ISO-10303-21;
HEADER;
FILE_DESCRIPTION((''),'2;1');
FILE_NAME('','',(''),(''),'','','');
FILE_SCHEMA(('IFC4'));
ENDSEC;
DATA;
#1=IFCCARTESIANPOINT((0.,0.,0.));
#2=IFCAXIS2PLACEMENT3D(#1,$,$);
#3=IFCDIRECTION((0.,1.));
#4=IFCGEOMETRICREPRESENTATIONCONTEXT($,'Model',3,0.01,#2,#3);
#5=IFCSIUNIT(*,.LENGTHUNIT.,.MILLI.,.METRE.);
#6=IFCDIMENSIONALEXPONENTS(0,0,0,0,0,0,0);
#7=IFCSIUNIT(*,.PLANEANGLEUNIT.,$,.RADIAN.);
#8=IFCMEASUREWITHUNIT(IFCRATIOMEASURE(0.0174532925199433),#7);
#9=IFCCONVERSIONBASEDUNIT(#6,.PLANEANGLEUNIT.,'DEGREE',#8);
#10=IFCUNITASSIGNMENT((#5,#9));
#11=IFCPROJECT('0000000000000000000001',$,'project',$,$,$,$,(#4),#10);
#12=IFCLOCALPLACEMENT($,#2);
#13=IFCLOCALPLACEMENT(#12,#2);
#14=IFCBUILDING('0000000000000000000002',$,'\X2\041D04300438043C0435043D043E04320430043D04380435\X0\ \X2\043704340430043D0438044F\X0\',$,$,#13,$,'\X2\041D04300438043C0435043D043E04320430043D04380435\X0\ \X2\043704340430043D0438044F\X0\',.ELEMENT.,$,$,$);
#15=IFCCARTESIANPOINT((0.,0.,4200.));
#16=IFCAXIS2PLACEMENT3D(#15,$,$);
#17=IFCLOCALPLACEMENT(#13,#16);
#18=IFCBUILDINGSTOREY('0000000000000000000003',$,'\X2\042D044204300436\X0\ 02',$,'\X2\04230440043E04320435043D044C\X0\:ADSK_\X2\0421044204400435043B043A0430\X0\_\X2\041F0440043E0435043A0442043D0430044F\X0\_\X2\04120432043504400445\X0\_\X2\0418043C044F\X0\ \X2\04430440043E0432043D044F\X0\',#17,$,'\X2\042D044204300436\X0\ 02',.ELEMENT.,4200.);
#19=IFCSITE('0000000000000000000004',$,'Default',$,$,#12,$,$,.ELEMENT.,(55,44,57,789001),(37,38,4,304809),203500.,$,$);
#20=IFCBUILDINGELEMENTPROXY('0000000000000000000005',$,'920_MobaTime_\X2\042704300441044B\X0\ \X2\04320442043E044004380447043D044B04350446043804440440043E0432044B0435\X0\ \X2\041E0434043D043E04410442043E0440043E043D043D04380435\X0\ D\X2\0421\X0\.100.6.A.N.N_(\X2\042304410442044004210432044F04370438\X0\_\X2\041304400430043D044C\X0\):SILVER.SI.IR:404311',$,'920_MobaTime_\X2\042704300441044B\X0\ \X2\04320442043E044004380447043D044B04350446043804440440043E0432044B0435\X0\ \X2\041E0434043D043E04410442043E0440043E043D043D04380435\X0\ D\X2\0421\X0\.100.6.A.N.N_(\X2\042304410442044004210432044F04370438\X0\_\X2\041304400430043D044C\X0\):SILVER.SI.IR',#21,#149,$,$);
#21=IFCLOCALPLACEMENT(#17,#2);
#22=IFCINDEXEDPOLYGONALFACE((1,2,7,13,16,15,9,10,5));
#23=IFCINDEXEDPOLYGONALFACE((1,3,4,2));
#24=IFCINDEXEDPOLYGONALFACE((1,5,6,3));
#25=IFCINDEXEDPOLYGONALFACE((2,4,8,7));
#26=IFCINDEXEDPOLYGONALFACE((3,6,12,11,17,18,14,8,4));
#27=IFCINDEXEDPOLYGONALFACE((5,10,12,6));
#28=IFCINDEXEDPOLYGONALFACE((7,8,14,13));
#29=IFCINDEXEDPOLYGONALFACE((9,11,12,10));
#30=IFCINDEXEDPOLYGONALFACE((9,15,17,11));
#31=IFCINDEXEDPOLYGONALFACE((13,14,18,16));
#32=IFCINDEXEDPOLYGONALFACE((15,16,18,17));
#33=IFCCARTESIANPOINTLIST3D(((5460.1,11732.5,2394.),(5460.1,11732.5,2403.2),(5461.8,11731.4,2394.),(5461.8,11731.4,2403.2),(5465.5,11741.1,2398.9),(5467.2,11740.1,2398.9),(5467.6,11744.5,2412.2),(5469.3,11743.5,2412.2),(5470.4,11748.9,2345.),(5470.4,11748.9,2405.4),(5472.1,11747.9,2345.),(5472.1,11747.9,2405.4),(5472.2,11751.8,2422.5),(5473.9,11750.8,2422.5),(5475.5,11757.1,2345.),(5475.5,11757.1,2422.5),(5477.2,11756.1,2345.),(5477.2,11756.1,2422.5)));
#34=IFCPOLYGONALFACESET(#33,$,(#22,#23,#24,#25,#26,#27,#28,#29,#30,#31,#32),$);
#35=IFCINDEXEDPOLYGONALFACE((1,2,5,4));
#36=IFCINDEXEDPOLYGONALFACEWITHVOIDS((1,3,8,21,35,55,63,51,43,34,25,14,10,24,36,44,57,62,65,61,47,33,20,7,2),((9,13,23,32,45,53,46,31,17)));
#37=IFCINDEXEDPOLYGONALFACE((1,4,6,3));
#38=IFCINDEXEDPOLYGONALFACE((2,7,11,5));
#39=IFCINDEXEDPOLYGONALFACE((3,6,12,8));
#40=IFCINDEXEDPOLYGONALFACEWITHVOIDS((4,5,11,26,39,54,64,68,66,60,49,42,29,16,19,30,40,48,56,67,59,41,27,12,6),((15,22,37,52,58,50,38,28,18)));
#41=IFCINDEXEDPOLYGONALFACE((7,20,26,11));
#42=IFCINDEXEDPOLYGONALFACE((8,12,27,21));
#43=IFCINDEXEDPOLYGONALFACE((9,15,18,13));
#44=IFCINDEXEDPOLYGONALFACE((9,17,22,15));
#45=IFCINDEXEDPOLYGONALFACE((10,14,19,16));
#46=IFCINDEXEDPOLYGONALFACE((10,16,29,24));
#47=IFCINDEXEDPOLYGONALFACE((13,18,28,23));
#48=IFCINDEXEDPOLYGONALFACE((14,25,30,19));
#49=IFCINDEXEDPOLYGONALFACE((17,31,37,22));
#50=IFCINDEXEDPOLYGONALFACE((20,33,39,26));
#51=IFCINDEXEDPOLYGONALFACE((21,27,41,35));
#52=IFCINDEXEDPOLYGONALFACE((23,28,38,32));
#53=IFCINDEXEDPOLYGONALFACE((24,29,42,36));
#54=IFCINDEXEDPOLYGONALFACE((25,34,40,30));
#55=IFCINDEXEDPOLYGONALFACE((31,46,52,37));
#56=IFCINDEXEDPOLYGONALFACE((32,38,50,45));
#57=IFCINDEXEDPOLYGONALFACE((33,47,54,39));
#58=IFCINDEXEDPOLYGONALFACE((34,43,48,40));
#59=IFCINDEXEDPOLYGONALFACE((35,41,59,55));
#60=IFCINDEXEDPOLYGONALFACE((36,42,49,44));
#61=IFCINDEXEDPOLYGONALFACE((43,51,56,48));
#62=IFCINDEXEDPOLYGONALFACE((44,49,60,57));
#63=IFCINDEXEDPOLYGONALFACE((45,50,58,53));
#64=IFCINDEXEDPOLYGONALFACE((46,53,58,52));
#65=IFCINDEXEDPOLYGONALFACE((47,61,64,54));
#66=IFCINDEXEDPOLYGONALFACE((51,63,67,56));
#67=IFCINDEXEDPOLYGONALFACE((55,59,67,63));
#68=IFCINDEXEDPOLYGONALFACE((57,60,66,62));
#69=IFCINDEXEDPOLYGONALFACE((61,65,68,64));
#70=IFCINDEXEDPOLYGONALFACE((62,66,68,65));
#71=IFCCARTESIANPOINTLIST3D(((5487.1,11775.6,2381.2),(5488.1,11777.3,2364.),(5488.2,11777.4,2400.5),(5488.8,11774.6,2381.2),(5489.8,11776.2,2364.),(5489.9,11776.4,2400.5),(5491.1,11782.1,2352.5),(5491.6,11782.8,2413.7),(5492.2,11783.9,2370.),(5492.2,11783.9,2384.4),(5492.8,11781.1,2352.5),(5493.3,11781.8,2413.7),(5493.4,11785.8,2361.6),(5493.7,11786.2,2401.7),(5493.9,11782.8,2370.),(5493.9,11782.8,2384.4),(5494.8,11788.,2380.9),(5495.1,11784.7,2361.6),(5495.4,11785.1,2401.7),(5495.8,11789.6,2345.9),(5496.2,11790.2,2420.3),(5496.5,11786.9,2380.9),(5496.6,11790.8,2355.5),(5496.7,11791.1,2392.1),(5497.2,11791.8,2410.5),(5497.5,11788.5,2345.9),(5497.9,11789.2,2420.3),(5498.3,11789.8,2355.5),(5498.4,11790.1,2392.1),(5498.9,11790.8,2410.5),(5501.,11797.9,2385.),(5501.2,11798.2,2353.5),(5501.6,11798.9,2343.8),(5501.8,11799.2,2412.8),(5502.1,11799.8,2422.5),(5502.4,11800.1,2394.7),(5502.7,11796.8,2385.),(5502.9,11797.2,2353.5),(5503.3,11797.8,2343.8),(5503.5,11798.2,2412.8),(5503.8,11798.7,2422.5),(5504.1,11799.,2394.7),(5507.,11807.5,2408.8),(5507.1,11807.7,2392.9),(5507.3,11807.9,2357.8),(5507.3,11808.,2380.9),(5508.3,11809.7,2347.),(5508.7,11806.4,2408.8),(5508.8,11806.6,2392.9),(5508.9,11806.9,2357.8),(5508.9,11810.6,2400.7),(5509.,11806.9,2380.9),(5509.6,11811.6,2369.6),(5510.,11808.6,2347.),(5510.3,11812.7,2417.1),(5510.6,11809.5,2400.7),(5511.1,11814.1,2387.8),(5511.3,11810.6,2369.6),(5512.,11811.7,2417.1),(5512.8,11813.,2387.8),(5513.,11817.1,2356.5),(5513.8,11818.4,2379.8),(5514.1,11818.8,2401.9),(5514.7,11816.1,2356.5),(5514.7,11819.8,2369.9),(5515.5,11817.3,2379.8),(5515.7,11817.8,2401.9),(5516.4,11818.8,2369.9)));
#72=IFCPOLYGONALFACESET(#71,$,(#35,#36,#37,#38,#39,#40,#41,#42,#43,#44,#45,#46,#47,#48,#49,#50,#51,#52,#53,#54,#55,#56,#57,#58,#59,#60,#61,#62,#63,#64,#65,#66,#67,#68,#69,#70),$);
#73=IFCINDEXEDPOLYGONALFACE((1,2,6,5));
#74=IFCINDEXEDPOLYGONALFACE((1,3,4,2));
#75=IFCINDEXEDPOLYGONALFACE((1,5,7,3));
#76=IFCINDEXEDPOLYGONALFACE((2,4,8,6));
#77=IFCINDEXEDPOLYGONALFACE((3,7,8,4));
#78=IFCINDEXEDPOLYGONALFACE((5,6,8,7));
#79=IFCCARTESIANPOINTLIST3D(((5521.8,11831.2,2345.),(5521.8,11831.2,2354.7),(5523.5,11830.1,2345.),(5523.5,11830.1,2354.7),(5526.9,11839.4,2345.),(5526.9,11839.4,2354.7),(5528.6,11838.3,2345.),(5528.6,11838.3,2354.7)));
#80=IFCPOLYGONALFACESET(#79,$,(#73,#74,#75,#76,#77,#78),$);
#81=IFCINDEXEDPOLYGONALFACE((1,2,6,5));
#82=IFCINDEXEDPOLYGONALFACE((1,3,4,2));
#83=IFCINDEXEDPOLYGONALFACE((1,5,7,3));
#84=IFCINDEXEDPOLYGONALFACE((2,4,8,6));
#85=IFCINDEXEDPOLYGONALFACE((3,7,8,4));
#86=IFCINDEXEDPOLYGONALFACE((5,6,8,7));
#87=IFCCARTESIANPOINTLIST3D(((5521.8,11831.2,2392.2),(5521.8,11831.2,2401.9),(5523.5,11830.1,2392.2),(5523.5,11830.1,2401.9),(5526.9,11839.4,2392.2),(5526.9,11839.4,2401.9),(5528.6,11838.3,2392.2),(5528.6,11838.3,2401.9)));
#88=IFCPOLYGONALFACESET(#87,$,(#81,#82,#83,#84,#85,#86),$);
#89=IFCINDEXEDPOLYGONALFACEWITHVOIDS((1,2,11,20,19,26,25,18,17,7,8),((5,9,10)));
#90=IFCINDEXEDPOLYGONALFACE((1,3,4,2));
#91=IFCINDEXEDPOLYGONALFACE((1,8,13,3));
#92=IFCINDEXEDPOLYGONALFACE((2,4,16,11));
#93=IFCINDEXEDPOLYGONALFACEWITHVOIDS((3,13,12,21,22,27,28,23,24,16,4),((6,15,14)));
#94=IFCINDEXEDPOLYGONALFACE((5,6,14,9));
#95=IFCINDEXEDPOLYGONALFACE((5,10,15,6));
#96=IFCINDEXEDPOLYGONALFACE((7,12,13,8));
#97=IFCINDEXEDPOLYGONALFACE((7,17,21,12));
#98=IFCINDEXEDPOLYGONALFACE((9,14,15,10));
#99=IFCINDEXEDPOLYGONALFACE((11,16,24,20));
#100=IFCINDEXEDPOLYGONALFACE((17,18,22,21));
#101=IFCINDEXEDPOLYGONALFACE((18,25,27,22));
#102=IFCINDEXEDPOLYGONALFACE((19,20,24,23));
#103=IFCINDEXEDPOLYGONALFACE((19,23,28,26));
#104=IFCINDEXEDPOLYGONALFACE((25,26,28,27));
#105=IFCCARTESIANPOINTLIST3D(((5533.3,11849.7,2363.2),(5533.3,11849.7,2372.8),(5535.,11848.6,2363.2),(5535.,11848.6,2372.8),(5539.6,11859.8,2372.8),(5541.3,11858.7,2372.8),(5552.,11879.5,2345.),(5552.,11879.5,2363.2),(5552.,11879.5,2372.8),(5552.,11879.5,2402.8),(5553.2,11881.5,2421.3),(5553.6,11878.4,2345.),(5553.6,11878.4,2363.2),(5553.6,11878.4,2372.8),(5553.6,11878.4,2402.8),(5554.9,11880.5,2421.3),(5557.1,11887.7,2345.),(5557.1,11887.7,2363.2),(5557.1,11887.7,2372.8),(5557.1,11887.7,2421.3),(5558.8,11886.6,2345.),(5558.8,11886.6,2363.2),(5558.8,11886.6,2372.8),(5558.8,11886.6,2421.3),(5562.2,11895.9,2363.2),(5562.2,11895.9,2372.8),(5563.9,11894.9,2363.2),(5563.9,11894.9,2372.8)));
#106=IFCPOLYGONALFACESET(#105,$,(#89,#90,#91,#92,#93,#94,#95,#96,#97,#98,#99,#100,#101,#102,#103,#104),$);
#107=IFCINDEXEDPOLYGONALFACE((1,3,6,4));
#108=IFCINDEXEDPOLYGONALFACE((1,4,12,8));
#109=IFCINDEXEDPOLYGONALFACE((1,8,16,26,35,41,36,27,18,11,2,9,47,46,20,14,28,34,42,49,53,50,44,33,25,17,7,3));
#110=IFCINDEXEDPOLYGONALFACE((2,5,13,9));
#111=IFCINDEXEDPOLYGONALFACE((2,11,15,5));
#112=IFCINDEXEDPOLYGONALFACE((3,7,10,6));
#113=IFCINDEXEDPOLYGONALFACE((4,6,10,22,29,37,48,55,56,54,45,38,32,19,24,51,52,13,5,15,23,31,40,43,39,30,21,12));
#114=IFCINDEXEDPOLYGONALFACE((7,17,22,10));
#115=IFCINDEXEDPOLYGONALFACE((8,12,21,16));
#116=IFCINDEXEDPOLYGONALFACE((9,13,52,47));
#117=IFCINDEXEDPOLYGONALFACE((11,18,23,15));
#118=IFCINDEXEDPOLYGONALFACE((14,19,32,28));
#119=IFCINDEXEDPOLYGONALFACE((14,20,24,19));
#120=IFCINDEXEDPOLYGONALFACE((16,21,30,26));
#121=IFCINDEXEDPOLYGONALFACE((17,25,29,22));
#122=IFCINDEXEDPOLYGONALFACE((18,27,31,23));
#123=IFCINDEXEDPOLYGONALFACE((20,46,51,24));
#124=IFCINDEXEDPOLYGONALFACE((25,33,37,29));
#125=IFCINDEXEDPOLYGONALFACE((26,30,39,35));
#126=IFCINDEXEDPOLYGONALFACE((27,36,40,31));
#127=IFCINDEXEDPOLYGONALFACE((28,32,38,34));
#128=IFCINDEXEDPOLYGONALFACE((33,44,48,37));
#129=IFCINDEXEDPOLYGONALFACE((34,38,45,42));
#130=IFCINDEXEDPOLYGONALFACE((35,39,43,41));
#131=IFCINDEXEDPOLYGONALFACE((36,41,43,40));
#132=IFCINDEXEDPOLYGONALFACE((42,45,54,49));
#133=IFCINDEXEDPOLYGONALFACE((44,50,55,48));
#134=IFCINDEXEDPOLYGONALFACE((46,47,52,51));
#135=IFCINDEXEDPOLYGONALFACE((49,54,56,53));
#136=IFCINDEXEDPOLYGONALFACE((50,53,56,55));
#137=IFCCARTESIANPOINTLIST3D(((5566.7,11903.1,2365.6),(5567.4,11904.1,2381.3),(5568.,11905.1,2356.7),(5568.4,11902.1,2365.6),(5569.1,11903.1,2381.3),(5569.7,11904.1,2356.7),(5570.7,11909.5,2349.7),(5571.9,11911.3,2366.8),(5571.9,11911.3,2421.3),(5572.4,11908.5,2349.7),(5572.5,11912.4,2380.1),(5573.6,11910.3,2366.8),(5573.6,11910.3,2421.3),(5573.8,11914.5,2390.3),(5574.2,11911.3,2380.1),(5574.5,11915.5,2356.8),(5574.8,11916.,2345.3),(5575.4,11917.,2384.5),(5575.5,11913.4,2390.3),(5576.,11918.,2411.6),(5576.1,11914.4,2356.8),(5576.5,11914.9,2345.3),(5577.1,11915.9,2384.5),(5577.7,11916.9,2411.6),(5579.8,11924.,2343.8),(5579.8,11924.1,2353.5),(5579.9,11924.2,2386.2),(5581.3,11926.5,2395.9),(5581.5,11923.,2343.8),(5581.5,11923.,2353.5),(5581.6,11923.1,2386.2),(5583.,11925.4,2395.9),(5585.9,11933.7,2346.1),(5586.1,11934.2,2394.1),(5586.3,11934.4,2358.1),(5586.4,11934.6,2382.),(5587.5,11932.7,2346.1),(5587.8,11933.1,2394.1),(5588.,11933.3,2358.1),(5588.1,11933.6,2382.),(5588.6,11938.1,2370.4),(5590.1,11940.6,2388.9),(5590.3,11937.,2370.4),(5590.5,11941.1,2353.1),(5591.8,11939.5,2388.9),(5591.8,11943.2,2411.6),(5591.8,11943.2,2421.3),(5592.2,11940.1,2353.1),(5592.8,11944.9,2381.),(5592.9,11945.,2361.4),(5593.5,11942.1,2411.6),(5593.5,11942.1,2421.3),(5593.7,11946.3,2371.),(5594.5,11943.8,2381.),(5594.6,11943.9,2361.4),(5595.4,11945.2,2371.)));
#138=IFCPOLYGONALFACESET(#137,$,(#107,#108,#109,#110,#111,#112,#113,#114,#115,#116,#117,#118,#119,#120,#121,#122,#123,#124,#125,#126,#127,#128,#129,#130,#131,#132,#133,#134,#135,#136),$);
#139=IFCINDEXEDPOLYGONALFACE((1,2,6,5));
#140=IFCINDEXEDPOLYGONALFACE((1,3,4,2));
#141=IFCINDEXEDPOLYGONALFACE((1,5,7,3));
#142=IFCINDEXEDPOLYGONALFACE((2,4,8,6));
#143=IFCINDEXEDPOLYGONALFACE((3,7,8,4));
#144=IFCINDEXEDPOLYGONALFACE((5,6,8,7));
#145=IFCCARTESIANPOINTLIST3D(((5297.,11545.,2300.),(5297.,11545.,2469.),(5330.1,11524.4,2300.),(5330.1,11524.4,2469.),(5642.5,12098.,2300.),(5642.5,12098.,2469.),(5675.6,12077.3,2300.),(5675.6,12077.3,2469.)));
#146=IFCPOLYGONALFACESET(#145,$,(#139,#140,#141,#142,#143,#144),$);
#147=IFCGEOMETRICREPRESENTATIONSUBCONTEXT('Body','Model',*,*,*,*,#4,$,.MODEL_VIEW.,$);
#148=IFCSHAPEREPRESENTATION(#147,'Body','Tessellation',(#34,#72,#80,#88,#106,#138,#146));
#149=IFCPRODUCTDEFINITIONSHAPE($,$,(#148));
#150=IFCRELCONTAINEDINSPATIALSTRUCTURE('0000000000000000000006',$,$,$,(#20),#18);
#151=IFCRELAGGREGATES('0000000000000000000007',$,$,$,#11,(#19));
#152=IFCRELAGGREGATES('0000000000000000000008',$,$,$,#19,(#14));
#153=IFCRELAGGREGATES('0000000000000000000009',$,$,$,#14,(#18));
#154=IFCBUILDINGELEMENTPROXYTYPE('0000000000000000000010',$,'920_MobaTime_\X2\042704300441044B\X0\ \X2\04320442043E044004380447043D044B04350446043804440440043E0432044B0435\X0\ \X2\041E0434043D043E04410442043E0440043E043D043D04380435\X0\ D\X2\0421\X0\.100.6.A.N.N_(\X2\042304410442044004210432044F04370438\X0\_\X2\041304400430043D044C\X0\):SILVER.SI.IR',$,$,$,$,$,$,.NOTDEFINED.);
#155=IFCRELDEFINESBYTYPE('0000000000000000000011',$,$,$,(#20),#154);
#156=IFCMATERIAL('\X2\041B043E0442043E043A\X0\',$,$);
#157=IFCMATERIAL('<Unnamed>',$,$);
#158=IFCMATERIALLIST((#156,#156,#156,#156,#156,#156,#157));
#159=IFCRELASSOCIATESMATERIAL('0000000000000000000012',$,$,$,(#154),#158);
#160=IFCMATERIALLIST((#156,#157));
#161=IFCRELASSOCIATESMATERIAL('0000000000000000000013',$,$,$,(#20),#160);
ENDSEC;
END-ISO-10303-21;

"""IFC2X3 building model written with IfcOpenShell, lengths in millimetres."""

from ifc_helpers import new_model, entity, si_unit, converted_unit, direction, frame, origin, origin_2d_with_axis, place, context, subcontext, project, spatial, polyline, rectangle, outline, extrude, source, transform, mapped, material, material_list, type_object, type_shapes, element, save


model = new_model("IFC2X3")

# Units and contexts
model_context = context("Model", 3, precision=0.01, world=origin(), true_north=direction((0.0, 1.0)))
body_context = subcontext(model_context, "Body", "Model", "MODEL_VIEW")
ifc_project = project(units=[si_unit("LENGTHUNIT", "METRE", prefix="MILLI"), converted_unit("PLANEANGLEUNIT", "DEGREE", entity("IfcRatioMeasure", 0.0174532925199433), si_unit("PLANEANGLEUNIT", "RADIAN"), dimensions=[0, 0, 0, 0, 0, 0, 0])], contexts=[model_context])

# Site, building, storey
site_placement = place(None, frame((0.0, 0.0, 0.0)))
site = spatial("IfcSite", under=ifc_project, at=site_placement, Name="Default", CompositionType="ELEMENT", RefLatitude=(55, 44, 57, 789001), RefLongitude=(37, 38, 4, 304809), RefElevation=203500.0)
building_placement = place(site_placement, origin())
building = spatial("IfcBuilding", under=site, at=building_placement, Name="Наименование здания", LongName="Наименование здания", CompositionType="ELEMENT")
storey_placement = place(building_placement, frame((0.0, 0.0, 4200.0)))
storey = spatial("IfcBuildingStorey", under=building, at=storey_placement, Name="Этаж 02", ObjectType="Уровень:ADSK_Стрелка_Проектная_Вверх_Имя уровня", LongName="Этаж 02", CompositionType="ELEMENT", Elevation=4200.0)

# Building element proxy
ifc_material_1 = material(Name="Лоток")
ifc_material_2 = material(Name="<Unnamed>")
ifc_material_list_1 = material_list([ifc_material_1, ifc_material_1, ifc_material_1, ifc_material_1, ifc_material_1, ifc_material_1, ifc_material_2])
building_element_proxy_type_1 = type_object("IfcBuildingElementProxyType", Name="920_MobaTime_Часы вторичныецифровые Односторонние DС.100.6.A.N.N_(УстрСвязи_Грань):SILVER.SI.IR", PredefinedType="NOTDEFINED", material=ifc_material_list_1)
shared_shape_1 = source(origin(), body_context, "Body", "SweptSolid", [
    extrude(outline(polyline([(-49.3, -13.1), (28.2, -13.1), (28.2, -6.8), (17.9, 1.8), (8.9, 16.0), (-0.3, 16.0), (4.6, 5.8), (11.1, -3.4), (-49.3, -3.4), (-49.3, -13.1)])), frame((-64.6, 9.8, 39.0), z_axis=(0.0, 0.0, 1.0), x_axis=(0.0, 1.0, 0.0)), (0.0, 0.0, 1.0), 2.0),
    extrude(outline(polyline([(2.2, -27.6), (19.0, -27.6), (30.5, -16.1), (33.3, -4.9), (31.0, 5.8), (21.8, 17.2), (5.2, 27.3), (-11.1, 33.0), (-24.0, 32.7), (-33.6, 27.6), (-40.3, 18.6), (-42.8, 5.7), (-38.0, -6.3), (-27.2, -15.0), (-17.5, -17.7), (-8.2, -16.4), (-0.3, -11.9), (5.1, -4.5), (7.3, 6.2), (4.0, 17.2), (18.5, 7.3), (23.6, -2.4), (22.0, -11.4), (14.2, -18.4), (5.3, -18.3), (2.2, -27.6)]), holes=[polyline([(-9.0, 23.3), (-1.3, 14.4), (-2.6, 2.0), (-11.4, -7.0), (-23.4, -6.1), (-32.2, 2.9), (-31.2, 15.1), (-25.6, 22.1), (-17.5, 24.9), (-9.0, 23.3)])]), frame((-2.7, 3.6, 39.0), z_axis=(0.0, 0.0, 1.0), x_axis=(-0.427649, 0.903945, 0.0)), (0.0, 0.0, 1.0), 2.0),
    extrude(rectangle(XDim=9.7, YDim=9.7, at=origin_2d_with_axis()), frame((40.6, -34.7, 39.0)), (0.0, 0.0, 1.0), 2.0),
    extrude(rectangle(XDim=9.7, YDim=9.7, at=origin_2d_with_axis()), frame((40.6, 12.6, 39.0)), (0.0, 0.0, 1.0), 2.0),
    extrude(outline(polyline([(-0.9, -28.1), (8.8, -28.1), (8.8, -9.9), (18.5, -9.9), (18.5, -0.2), (8.8, -0.2), (8.8, 48.3), (1.5, 48.3), (-36.0, -0.2), (-36.0, -9.9), (-0.9, -9.9), (-0.9, -28.1)]), holes=[polyline([(-0.9, -0.2), (-24.1, -0.2), (-0.9, 29.7), (-0.9, -0.2)])]), frame((93.6, -11.4, 39.0)), (0.0, 0.0, 1.0), 2.0),
    extrude(outline(polyline([(3.3, -28.3), (12.5, -28.3), (20.5, -25.0), (26.8, -18.8), (30.7, -10.0), (31.4, 1.6), (26.9, 11.8), (20.1, 18.4), (11.1, 22.3), (1.0, 23.3), (-7.9, 20.4), (-14.9, 14.5), (-18.9, 6.2), (-17.1, -9.0), (-36.7, 0.5), (-29.1, 29.3), (-38.5, 31.7), (-48.1, -4.6), (-11.6, -23.0), (-8.0, -14.0), (-10.8, -7.6), (-10.2, 1.1), (-3.0, 11.8), (9.2, 12.8), (20.0, 5.4), (21.3, -7.5), (15.5, -16.4), (4.6, -18.6), (3.3, -28.3)])), frame((147.1, -8.5, 39.0), z_axis=(0.0, 0.0, 1.0), x_axis=(0.256974, -0.966418, 0.0)), (0.0, 0.0, 1.0), 2.0),
    extrude(rectangle(XDim=652.0, YDim=169.0, at=origin_2d_with_axis()), frame((0.0, 0.0, 0.0), z_axis=(0.0, 0.0, 1.0), x_axis=(-1.0, 0.0, 0.0)), (0.0, 0.0, 1.0), 39.0),
])
type_shapes(building_element_proxy_type_1, [shared_shape_1])
ifc_material_list_2 = material_list([ifc_material_1, ifc_material_2])
proxy_1_placement = place(storey_placement, frame((5469.7, 11821.5, 2384.5), z_axis=(0.848048, -0.529919, 0.0), x_axis=(0.529919, 0.848048, 0.0)))
element("IfcBuildingElementProxy", 1, at=proxy_1_placement, inside=storey, type_object=building_element_proxy_type_1, material=ifc_material_list_2, Name="920_MobaTime_Часы вторичныецифровые Односторонние DС.100.6.A.N.N_(УстрСвязи_Грань):SILVER.SI.IR:404311", ObjectType="920_MobaTime_Часы вторичныецифровые Односторонние DС.100.6.A.N.N_(УстрСвязи_Грань):SILVER.SI.IR", context=body_context, shape_type="MappedRepresentation", body=[
    mapped(shared_shape_1, transform((0.0, 0.0, 0.0), scale=1.0)),
])

save(model, "model.ifc")
